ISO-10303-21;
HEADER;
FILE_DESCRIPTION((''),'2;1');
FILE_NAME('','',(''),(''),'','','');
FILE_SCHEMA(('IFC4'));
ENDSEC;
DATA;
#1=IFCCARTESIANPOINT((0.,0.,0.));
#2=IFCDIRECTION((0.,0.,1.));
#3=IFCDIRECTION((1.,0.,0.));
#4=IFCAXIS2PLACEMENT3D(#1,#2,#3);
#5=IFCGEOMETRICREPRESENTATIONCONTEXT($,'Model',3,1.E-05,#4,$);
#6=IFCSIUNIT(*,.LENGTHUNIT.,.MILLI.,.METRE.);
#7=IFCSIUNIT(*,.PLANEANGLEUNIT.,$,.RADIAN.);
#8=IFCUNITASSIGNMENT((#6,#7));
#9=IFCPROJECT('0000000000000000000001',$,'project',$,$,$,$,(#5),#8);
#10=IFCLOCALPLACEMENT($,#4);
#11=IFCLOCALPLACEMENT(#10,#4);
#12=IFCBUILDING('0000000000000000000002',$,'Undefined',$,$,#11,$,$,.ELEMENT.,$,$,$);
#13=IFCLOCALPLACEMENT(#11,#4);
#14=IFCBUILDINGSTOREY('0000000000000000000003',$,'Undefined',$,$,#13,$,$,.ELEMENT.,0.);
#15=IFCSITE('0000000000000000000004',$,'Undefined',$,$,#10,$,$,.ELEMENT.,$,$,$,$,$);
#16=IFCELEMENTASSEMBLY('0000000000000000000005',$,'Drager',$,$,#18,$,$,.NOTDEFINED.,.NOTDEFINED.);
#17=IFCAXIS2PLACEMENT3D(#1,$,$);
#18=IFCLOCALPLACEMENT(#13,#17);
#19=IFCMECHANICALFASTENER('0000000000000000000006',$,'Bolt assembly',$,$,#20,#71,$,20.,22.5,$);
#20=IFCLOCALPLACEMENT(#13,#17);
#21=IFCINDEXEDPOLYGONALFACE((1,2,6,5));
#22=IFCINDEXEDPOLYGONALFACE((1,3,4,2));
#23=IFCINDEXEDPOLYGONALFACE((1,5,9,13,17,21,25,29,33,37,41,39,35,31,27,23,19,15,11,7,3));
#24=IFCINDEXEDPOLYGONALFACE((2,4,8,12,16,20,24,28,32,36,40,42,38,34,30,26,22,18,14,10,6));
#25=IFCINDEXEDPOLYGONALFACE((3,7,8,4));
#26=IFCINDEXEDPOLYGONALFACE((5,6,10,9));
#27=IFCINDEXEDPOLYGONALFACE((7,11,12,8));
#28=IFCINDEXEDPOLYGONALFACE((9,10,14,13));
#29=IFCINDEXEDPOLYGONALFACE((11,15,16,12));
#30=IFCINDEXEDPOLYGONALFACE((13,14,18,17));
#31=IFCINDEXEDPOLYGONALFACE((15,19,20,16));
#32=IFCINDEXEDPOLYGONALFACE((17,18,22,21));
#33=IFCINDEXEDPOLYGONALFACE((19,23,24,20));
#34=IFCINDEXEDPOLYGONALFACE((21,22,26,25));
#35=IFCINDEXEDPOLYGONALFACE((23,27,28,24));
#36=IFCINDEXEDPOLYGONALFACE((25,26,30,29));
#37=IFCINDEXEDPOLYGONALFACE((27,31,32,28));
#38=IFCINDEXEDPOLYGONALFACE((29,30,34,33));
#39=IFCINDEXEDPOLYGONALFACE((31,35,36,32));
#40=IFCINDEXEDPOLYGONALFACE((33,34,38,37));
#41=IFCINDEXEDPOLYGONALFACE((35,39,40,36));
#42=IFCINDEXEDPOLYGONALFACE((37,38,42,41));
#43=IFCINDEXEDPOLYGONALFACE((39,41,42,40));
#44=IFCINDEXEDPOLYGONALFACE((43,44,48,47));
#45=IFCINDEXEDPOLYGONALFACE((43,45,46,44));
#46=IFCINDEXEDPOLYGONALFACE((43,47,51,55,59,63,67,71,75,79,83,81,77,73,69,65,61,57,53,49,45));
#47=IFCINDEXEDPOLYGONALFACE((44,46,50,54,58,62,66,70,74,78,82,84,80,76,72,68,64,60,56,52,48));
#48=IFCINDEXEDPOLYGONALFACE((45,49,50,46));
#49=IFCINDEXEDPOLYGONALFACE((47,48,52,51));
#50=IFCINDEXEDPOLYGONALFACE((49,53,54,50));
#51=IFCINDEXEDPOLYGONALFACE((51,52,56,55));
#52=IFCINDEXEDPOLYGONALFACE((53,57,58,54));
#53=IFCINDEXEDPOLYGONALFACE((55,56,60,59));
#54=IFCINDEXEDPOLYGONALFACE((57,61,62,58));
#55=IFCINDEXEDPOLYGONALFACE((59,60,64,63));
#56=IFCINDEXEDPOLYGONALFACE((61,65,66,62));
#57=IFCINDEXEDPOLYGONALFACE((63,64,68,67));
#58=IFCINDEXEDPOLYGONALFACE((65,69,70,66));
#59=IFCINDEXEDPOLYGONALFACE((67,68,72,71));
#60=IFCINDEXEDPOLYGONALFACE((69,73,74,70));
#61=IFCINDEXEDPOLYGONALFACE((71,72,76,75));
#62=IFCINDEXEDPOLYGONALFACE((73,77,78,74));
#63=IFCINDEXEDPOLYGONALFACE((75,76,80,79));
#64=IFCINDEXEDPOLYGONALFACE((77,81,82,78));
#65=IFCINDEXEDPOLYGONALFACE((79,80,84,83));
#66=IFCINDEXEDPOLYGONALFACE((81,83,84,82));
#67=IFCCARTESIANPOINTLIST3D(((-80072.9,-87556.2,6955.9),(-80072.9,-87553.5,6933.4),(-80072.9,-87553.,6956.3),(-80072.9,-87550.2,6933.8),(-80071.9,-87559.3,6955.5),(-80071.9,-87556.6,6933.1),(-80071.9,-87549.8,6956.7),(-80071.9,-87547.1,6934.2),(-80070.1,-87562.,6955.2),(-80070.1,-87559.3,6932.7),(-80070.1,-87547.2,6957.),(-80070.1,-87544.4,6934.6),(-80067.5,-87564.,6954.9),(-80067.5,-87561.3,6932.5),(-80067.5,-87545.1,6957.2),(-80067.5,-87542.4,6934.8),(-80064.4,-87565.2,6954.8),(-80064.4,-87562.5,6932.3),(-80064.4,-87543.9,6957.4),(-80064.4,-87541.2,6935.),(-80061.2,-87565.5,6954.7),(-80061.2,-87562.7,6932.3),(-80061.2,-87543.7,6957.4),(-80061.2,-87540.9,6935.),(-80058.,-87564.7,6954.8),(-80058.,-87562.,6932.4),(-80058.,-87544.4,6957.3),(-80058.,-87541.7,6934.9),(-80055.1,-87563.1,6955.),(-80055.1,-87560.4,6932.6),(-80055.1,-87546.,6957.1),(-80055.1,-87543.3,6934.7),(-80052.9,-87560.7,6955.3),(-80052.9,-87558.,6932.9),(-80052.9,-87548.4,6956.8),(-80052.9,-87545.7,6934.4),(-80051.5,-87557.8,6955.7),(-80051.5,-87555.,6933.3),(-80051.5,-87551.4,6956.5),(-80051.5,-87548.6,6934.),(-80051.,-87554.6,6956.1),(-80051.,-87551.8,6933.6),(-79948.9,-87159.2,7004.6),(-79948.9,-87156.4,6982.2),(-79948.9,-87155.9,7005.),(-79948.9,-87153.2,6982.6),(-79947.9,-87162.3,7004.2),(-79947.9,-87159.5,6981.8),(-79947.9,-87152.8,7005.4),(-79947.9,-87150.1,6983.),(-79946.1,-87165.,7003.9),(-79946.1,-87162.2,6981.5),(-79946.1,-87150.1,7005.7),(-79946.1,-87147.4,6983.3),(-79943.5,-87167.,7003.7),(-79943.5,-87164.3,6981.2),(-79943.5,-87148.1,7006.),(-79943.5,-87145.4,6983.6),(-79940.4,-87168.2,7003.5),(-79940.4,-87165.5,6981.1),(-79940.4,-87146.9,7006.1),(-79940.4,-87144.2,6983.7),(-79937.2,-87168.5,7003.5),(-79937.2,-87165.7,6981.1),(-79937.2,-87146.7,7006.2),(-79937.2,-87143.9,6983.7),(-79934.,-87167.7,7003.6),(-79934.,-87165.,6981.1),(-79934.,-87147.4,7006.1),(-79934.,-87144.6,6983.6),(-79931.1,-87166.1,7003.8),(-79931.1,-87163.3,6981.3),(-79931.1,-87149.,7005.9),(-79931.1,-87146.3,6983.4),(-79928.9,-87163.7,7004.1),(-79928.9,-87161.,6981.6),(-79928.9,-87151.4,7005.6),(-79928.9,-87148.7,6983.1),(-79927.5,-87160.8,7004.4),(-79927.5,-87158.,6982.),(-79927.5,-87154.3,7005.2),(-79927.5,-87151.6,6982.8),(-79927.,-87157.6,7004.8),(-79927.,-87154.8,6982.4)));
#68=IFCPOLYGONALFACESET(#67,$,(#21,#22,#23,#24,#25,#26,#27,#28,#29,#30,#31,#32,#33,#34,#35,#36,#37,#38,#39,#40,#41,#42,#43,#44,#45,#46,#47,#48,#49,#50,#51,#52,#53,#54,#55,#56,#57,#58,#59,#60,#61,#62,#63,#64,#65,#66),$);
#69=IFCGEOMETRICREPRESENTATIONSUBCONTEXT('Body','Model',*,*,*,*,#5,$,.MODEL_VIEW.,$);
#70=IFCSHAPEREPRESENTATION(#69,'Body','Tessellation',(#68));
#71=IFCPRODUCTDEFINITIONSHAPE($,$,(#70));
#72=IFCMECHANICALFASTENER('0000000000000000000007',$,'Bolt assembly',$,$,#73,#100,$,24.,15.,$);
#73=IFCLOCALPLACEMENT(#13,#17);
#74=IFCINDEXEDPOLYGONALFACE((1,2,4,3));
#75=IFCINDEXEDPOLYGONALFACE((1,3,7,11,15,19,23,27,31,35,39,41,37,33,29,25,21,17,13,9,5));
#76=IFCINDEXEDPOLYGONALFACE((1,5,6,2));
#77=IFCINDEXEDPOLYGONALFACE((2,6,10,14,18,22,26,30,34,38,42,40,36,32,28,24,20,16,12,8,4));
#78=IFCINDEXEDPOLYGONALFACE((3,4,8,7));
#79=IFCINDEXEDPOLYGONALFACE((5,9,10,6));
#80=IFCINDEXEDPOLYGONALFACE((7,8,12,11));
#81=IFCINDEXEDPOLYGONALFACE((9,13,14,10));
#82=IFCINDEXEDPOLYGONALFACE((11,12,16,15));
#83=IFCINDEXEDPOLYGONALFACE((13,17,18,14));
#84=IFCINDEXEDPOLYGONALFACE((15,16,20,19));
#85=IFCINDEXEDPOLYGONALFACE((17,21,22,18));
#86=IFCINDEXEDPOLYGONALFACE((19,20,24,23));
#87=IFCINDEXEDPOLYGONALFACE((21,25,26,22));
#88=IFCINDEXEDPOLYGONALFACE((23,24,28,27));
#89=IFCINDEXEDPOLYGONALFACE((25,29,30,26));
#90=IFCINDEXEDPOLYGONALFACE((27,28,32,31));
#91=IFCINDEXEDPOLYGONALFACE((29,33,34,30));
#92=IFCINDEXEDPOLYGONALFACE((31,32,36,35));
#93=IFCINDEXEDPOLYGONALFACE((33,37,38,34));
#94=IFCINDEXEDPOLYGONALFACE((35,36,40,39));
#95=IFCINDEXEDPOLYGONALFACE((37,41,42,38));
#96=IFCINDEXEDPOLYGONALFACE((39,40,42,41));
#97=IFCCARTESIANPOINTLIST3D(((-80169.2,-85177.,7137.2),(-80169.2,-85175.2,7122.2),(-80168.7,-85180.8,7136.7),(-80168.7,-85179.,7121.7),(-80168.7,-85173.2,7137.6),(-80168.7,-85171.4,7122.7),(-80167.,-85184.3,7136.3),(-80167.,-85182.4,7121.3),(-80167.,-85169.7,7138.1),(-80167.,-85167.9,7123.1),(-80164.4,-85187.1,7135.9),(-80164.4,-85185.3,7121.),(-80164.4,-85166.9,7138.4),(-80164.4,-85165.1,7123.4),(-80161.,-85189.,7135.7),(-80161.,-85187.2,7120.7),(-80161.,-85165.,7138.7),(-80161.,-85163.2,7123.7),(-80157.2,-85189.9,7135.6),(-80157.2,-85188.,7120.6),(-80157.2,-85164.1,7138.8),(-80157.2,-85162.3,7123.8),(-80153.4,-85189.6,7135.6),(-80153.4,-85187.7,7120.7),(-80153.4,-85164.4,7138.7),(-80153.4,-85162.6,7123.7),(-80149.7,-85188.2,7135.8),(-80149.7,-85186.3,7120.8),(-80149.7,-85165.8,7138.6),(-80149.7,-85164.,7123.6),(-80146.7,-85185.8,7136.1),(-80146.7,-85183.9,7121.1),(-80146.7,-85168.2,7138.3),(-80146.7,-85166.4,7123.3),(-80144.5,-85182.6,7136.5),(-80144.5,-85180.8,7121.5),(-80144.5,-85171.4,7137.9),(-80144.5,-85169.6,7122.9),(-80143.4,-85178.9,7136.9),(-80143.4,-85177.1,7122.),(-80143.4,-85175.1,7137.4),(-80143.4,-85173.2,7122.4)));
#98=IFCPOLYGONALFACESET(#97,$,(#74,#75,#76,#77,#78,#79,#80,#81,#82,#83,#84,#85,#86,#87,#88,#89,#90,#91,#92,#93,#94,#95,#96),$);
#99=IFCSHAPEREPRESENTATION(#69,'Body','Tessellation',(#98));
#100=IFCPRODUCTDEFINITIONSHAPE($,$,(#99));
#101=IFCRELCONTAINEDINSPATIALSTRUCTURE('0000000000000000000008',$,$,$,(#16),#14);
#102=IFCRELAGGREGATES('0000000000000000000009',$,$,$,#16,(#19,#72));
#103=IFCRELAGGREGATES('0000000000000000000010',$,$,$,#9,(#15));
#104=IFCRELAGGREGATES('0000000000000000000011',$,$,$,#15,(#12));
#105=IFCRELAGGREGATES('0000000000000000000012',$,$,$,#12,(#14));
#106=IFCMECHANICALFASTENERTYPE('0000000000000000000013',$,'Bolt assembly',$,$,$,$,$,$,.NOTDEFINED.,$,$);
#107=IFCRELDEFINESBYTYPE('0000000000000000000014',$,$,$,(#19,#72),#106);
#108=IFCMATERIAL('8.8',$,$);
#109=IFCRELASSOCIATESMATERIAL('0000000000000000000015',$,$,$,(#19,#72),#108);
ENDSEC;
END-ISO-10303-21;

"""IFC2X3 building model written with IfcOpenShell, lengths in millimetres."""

from ifc_helpers import new_model, si_unit, frame, origin_with_axes, origin_2d_with_axis, place, context, subcontext, project, spatial, circle, extrude, source, transform, mapped, material, type_object, element, aggregate, save


model = new_model("IFC2X3")

# Units and contexts
model_context = context("Model", 3, precision=1e-05, world=origin_with_axes())
body_context = subcontext(model_context, "Body", "Model", "MODEL_VIEW")
ifc_project = project(units=[si_unit("LENGTHUNIT", "METRE", prefix="MILLI"), si_unit("PLANEANGLEUNIT", "RADIAN")], contexts=[model_context])

# Site, building, storey
site_placement = place(None, origin_with_axes())
site = spatial("IfcSite", under=ifc_project, at=site_placement, Name="Undefined", CompositionType="ELEMENT")
building_placement = place(site_placement, origin_with_axes())
building = spatial("IfcBuilding", under=site, at=building_placement, Name="Undefined", CompositionType="ELEMENT")
storey_placement = place(building_placement, origin_with_axes())
storey = spatial("IfcBuildingStorey", under=building, at=storey_placement, Name="Undefined", CompositionType="ELEMENT", Elevation=0.0)

# Element assembly
assembly_1_placement = place(storey_placement, origin_with_axes())
assembly_1 = element("IfcElementAssembly", 1, at=assembly_1_placement, inside=storey, Name="Drager", AssemblyPlace="NOTDEFINED", PredefinedType="NOTDEFINED")

# Shared definitions
ifc_material_1 = material(Name="8.8")
mechanical_fastener_type = type_object("IfcMechanicalFastenerType", Name="Bolt assembly")

# Mechanical fasteners
shared_shape_1 = source(origin_with_axes(), body_context, "Body", "SweptSolid", [
    extrude(circle(Radius=11.0, at=origin_2d_with_axis()), frame((0.0, 0.0, 0.0), z_axis=(0.0, 1.0, 0.0), x_axis=(1.0, 0.0, 0.0)), (0.0, 0.0, 1.0), 22.6),
])
mechanical_fastener_1_placement = place(assembly_1_placement, frame((-80150.0, -87356.1, 6980.5), z_axis=(0.0, 0.992546, 0.121869), x_axis=(1.0, 0.0, 0.0)))
mechanical_fastener_1 = element("IfcMechanicalFastener", 2, at=mechanical_fastener_1_placement, type_object=mechanical_fastener_type, material=ifc_material_1, Name="Bolt assembly", NominalDiameter=20.0, NominalLength=22.5, context=body_context, shape_type="MappedRepresentation", body=[
    mapped(shared_shape_1, transform((88.0, 0.0, -200.0))),
    mapped(shared_shape_1, transform((212.0, 0.0, 200.0))),
])
shared_shape_2 = source(origin_with_axes(), body_context, "Body", "SweptSolid", [
    extrude(circle(Radius=13.0, at=origin_2d_with_axis()), frame((0.0, -7.5, 0.0), z_axis=(0.0, 1.0, 0.0), x_axis=(1.0, 0.0, 0.0)), (0.0, 0.0, 1.0), 15.1),
])
mechanical_fastener_2_placement = place(assembly_1_placement, frame((-80156.2, -85176.1, 7129.7), z_axis=(0.0, -0.992546, -0.121869), x_axis=(-1.0, 0.0, 0.0)))
mechanical_fastener_2 = element("IfcMechanicalFastener", 3, at=mechanical_fastener_2_placement, type_object=mechanical_fastener_type, material=ifc_material_1, Name="Bolt assembly", NominalDiameter=24.0, NominalLength=15.0, context=body_context, shape_type="MappedRepresentation", body=[
    mapped(shared_shape_2, transform((0.0, 0.0, 0.0))),
])
aggregate(assembly_1, [mechanical_fastener_1, mechanical_fastener_2])

save(model, "model.ifc")
